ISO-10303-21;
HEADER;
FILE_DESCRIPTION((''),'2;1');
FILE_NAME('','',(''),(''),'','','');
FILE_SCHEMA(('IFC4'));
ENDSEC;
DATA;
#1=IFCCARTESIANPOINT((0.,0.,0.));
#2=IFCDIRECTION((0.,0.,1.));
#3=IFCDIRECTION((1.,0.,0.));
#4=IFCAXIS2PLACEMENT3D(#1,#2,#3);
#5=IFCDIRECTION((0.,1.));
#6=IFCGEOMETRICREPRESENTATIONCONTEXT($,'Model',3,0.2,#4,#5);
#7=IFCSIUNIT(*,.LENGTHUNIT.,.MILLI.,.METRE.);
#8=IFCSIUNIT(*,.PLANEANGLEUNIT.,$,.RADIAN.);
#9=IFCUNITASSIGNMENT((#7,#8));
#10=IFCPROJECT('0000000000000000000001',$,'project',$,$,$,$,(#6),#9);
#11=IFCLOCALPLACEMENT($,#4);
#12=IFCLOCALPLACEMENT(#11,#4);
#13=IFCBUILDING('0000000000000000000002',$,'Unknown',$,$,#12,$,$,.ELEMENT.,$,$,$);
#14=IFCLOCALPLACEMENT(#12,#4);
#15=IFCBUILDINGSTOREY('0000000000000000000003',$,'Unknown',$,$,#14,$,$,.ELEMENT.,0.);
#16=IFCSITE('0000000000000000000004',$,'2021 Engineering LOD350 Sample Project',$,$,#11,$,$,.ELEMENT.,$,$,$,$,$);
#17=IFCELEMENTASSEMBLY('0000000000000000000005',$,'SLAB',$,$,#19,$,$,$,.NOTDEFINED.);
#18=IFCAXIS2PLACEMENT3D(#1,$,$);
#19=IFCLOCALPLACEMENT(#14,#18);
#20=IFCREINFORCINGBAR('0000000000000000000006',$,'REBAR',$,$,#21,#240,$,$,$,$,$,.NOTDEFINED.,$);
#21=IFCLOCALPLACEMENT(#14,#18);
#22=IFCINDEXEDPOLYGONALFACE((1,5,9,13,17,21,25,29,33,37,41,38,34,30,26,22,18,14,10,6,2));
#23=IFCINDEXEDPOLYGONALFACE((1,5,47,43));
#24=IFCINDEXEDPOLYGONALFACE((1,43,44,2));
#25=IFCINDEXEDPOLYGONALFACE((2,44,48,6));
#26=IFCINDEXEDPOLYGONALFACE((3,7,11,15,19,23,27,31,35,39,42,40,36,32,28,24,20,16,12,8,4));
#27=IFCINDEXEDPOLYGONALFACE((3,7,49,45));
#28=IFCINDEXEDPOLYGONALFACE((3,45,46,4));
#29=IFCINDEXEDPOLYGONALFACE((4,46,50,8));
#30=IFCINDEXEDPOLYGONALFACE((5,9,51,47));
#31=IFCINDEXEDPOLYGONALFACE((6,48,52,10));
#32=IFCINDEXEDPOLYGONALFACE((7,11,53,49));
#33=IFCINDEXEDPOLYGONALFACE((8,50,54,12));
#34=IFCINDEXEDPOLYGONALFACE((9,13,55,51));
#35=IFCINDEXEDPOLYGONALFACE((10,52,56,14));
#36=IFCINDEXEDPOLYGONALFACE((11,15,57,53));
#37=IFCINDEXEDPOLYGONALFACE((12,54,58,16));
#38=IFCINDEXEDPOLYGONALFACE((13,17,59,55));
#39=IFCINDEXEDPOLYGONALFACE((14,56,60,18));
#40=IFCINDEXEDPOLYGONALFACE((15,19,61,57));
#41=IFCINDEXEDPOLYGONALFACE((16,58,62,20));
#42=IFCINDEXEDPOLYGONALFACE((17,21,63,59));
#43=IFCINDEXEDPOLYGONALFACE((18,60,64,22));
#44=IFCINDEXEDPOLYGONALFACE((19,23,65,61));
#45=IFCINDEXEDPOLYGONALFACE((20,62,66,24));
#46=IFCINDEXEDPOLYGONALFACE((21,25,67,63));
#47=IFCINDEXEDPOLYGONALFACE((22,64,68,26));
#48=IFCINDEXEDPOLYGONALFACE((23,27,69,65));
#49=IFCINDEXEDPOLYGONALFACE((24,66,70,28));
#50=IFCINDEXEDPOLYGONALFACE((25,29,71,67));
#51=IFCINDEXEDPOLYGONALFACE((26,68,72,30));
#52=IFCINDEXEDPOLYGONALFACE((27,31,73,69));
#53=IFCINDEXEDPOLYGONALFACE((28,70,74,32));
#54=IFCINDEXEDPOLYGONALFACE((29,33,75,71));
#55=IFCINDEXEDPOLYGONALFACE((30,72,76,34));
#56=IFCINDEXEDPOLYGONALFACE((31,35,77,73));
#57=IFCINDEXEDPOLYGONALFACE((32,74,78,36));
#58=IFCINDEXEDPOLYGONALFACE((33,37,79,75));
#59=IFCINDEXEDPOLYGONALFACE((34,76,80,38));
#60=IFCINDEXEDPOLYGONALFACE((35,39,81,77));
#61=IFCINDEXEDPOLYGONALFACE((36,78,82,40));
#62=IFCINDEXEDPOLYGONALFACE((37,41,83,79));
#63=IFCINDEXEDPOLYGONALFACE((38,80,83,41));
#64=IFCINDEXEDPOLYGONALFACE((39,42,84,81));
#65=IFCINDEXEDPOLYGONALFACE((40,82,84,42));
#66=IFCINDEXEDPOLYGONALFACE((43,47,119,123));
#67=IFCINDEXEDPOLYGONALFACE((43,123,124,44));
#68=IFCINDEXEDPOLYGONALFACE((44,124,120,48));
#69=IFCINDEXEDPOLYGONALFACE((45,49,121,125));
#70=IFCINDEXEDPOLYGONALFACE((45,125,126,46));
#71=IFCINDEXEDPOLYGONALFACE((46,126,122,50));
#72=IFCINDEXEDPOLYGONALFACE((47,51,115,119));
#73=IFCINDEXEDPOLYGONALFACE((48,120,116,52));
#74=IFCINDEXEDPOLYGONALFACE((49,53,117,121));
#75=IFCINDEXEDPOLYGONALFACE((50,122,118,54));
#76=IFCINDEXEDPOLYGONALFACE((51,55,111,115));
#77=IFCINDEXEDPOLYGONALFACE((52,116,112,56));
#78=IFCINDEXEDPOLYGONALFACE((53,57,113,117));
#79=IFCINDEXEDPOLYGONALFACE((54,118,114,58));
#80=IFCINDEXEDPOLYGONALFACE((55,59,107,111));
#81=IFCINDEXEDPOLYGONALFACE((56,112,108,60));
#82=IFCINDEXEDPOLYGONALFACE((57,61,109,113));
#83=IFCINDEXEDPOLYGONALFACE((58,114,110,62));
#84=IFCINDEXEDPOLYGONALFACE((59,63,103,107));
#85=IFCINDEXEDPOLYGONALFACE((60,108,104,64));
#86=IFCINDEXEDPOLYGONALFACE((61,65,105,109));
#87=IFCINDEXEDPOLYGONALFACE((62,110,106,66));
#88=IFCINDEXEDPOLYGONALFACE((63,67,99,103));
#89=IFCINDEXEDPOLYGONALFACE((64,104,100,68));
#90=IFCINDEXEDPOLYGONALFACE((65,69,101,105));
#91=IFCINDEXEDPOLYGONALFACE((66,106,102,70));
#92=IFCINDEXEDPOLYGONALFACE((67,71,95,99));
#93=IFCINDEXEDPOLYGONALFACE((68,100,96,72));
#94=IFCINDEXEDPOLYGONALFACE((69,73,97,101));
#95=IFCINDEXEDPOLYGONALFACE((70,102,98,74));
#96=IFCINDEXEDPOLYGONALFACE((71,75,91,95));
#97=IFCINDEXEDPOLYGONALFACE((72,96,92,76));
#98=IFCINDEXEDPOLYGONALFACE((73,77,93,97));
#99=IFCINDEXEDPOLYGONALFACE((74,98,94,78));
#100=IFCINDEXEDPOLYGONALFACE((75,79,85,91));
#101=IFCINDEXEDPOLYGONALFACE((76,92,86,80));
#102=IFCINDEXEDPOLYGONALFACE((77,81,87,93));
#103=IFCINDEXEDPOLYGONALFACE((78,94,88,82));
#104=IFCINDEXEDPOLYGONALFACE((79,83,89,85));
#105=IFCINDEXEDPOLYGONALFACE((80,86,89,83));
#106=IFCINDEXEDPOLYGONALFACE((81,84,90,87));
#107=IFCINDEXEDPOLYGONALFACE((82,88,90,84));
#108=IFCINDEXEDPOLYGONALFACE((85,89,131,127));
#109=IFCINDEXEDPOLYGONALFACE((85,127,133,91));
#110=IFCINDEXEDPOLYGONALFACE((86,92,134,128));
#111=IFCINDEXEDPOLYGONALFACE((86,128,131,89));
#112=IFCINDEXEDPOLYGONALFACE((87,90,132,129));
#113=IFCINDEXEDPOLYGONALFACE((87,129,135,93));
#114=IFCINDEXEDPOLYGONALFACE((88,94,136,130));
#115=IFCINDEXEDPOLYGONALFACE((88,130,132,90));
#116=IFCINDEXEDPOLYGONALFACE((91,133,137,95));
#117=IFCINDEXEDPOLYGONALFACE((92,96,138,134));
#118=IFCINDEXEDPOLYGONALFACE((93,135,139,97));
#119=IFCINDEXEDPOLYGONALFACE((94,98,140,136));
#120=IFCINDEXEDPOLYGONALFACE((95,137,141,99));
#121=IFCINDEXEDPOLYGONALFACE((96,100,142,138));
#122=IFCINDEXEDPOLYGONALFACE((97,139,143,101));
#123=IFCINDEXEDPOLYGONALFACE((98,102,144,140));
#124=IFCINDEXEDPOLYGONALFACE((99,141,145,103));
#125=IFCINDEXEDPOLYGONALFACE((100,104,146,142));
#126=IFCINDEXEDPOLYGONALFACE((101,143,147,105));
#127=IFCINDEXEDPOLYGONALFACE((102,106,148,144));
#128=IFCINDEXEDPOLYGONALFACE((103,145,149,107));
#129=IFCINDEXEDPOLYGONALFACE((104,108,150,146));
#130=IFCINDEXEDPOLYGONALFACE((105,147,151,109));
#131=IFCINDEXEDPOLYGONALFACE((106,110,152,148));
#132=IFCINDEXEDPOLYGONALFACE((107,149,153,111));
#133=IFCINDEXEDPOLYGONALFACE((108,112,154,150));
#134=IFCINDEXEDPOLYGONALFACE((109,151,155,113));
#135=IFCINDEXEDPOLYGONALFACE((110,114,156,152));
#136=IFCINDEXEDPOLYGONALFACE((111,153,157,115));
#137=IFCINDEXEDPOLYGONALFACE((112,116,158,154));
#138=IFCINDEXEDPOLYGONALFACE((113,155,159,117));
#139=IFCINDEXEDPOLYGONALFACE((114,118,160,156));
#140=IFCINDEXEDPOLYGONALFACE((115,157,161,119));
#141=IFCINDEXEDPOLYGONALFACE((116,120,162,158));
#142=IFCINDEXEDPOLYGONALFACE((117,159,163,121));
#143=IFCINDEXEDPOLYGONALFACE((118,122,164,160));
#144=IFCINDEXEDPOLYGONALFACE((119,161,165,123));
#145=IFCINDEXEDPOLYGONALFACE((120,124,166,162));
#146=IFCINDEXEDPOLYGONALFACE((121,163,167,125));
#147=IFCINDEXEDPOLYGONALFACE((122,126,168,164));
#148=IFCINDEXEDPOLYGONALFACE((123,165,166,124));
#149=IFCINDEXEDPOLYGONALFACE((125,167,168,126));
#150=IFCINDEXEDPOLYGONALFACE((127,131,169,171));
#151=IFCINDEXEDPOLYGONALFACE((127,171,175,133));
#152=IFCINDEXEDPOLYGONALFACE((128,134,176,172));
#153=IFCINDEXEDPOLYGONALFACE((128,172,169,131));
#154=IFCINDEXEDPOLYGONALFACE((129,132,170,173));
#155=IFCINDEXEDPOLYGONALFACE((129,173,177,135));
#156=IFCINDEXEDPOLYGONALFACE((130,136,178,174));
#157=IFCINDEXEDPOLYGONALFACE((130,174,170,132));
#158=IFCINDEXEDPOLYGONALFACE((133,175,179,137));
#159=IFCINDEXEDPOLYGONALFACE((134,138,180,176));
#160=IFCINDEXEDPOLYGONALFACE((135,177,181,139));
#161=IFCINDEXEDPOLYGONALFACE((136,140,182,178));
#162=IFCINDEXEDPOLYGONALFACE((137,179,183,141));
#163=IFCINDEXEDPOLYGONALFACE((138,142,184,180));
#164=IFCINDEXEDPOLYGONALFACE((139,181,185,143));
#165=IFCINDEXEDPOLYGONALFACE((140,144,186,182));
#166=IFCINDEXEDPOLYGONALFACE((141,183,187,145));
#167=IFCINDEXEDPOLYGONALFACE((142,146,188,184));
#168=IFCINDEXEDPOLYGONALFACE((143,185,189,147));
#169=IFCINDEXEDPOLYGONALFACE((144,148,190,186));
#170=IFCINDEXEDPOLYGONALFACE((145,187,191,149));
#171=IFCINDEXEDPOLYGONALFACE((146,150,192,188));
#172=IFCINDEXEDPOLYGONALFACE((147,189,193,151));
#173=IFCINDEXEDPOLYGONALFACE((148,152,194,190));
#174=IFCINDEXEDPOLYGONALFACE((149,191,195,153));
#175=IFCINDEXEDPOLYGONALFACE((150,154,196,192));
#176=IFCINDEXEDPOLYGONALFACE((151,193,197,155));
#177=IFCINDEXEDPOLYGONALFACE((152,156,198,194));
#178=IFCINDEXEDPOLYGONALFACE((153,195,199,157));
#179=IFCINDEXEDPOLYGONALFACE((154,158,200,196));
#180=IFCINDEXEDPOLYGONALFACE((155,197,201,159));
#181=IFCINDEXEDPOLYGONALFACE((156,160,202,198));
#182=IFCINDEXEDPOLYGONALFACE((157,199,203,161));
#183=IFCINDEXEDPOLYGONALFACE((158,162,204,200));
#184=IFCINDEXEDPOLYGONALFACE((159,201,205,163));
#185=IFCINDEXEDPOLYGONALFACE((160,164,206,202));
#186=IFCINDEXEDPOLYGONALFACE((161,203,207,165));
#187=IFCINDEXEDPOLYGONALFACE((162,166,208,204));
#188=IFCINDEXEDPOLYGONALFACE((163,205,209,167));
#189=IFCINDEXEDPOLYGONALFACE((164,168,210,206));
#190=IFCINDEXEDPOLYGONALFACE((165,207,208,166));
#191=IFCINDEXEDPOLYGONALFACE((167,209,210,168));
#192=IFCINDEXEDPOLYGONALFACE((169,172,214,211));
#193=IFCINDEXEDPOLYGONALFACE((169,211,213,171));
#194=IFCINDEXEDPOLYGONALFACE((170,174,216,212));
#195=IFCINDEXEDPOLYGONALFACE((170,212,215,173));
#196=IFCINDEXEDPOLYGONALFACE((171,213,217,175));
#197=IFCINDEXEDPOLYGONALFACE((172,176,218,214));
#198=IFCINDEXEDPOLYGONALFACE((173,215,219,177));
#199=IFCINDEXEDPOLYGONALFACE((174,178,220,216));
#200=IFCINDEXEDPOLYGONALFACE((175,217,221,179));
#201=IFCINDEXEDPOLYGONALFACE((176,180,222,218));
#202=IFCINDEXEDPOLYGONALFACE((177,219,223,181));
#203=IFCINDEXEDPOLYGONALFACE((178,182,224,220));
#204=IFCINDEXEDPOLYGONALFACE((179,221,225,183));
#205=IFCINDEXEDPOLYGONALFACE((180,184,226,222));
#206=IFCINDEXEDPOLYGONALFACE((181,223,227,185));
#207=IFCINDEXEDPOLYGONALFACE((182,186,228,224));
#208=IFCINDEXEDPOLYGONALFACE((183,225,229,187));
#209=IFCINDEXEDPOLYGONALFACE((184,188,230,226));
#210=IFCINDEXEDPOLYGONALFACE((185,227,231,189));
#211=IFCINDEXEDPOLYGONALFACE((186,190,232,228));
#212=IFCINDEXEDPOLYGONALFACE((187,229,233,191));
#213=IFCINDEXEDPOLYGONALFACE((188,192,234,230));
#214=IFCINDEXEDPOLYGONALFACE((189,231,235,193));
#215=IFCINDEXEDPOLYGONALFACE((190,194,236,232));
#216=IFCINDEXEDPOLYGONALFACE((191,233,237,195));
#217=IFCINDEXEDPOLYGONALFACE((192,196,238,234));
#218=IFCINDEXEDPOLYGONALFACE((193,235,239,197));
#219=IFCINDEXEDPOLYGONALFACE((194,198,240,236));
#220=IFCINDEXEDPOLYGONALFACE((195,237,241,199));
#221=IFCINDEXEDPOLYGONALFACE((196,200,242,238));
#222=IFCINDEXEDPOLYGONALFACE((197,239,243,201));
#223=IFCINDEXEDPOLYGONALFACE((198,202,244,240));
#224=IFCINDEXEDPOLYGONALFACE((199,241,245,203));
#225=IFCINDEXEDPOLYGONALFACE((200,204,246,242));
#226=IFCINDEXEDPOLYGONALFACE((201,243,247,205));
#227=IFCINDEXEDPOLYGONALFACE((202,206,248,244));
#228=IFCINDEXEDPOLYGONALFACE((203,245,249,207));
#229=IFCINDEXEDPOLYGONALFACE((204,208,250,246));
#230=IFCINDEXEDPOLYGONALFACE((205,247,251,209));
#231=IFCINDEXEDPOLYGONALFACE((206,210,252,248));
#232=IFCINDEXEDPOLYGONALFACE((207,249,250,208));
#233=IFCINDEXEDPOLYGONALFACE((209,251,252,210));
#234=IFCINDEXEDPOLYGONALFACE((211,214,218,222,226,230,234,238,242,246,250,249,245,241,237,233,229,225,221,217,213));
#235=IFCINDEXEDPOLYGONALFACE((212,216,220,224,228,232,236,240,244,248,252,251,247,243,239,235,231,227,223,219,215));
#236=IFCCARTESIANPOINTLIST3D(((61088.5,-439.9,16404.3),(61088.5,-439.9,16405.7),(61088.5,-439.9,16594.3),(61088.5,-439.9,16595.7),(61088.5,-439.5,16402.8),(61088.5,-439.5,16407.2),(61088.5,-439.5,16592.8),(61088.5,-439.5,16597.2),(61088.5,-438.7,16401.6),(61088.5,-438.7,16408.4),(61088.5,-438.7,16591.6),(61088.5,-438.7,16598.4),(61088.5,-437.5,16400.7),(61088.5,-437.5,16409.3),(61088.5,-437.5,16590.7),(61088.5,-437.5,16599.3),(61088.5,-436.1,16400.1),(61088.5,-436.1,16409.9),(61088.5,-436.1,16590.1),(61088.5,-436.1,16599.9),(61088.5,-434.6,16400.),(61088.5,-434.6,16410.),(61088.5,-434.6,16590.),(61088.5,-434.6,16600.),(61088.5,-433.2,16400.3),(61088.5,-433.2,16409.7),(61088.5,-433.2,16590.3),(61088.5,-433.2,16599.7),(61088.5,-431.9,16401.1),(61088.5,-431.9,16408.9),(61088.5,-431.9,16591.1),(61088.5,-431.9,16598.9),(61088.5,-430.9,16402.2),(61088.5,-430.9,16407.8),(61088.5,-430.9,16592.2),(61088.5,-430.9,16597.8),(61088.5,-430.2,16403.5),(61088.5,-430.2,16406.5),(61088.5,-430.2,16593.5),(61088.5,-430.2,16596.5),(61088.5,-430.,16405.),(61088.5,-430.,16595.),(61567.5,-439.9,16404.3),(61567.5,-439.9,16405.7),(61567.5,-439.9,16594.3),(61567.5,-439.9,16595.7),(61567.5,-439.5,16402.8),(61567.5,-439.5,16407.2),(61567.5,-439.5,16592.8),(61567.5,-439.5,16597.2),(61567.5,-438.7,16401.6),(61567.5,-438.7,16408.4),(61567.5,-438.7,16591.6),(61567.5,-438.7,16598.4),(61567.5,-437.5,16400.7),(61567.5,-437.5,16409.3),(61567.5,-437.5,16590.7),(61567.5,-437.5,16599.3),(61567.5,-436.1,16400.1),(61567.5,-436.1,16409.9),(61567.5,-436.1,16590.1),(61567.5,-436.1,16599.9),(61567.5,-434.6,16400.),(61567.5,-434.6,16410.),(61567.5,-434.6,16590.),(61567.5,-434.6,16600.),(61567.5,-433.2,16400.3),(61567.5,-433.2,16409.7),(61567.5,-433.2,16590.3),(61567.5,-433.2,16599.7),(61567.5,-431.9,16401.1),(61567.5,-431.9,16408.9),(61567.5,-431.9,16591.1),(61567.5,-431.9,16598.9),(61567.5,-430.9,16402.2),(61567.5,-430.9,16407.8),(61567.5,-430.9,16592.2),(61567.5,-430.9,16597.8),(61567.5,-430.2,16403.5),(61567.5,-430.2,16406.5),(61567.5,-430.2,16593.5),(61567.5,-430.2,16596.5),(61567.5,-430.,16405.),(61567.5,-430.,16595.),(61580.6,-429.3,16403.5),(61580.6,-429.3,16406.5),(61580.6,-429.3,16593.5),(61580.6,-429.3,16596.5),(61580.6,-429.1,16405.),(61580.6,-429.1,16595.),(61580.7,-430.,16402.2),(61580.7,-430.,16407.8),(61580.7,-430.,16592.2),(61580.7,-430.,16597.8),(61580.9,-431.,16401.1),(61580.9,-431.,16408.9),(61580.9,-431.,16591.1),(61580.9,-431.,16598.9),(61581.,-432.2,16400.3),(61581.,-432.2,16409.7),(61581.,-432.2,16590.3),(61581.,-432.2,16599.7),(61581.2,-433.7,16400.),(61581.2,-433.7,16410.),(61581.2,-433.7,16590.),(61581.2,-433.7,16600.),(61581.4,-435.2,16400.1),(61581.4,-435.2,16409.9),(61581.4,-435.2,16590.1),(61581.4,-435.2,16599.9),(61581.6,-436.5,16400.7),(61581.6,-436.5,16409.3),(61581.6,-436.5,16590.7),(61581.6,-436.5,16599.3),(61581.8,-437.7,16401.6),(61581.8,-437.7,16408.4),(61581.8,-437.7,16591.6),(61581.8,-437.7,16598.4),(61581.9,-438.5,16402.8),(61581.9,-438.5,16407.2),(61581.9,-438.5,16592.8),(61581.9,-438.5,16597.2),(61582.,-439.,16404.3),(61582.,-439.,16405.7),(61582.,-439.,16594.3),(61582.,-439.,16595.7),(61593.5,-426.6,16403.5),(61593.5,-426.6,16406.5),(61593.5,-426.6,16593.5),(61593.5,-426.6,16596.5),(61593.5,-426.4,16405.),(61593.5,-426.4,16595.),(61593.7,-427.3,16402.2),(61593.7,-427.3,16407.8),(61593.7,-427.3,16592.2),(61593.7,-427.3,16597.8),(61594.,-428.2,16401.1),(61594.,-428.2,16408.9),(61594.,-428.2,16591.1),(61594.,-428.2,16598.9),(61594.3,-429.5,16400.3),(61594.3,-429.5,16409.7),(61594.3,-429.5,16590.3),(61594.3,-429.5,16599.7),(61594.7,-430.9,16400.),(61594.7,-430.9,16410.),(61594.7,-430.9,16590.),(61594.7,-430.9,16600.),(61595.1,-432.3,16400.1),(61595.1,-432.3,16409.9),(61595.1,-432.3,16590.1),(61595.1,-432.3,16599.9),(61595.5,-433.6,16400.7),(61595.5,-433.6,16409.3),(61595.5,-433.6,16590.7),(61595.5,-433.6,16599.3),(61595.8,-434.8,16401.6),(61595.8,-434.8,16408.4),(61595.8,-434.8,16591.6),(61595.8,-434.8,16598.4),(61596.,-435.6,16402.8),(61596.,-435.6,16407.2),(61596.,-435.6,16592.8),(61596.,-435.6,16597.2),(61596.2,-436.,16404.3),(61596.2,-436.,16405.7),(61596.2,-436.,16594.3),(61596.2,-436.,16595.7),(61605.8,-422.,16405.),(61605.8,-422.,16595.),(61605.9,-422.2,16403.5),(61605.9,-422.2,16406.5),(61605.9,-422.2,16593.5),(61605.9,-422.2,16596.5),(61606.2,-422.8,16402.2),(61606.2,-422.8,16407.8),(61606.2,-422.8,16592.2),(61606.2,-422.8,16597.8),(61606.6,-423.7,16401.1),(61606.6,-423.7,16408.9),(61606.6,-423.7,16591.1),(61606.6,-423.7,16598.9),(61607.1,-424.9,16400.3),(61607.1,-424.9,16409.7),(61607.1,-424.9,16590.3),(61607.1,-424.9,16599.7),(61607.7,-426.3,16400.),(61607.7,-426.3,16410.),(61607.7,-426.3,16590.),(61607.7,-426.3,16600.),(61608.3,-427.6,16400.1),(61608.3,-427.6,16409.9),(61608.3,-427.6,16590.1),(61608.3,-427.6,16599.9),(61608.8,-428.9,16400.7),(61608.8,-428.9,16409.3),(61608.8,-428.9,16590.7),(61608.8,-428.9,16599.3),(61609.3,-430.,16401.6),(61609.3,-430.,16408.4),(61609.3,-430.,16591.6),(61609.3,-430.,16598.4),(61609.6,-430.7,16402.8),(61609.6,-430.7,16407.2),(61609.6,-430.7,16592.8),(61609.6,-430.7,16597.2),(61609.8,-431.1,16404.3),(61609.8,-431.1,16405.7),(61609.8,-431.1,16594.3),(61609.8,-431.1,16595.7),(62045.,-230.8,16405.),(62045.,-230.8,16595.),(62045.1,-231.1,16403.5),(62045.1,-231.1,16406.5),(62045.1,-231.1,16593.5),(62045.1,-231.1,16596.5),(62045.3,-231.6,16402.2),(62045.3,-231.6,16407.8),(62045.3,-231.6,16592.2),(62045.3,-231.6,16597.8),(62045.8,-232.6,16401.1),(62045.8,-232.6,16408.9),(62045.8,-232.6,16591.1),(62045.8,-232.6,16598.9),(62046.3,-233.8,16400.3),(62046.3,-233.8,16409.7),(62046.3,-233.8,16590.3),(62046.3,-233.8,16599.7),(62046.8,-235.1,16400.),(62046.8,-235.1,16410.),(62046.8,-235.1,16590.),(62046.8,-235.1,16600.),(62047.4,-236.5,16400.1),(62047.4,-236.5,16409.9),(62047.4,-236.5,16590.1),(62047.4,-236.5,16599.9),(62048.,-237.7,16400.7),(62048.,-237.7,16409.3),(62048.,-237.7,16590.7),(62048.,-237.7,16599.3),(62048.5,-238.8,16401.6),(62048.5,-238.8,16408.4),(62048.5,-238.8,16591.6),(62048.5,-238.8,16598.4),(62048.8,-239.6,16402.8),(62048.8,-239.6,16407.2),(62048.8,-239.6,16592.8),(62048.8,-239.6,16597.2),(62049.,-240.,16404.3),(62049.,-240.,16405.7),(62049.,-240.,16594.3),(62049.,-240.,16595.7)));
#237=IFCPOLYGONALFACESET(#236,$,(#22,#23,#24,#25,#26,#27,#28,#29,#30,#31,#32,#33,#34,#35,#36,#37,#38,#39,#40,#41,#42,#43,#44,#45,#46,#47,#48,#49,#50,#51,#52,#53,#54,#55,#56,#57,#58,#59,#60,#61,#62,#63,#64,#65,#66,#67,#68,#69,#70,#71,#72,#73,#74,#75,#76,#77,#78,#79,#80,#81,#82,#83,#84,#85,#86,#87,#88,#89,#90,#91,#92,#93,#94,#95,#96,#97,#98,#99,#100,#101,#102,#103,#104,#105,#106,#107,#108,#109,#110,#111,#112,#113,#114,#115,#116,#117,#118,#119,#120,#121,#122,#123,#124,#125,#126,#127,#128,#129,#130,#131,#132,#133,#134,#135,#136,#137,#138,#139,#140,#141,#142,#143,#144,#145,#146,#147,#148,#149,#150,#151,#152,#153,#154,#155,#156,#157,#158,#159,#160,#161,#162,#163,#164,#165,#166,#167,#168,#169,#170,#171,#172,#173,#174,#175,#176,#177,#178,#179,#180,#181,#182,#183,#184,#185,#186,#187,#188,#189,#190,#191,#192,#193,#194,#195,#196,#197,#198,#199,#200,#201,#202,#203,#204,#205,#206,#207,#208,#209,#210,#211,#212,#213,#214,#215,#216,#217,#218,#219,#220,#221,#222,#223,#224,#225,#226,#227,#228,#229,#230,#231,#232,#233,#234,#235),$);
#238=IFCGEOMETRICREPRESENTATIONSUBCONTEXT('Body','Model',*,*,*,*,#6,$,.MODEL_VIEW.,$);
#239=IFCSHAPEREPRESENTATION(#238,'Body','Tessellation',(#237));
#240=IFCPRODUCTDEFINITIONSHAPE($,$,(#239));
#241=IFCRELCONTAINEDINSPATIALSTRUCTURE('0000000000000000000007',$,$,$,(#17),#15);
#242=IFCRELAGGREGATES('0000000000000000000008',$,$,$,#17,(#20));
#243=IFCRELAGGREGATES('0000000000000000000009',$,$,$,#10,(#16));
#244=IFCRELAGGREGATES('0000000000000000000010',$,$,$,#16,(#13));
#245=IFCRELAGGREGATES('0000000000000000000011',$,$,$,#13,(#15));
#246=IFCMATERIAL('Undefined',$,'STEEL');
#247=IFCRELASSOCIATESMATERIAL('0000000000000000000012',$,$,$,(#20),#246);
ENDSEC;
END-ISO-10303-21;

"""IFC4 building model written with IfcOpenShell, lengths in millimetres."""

from ifc_helpers import new_model, entity, si_unit, direction, frame, origin_with_axes, place, context, subcontext, project, spatial, source, transform, mapped, material, element, aggregate, save


model = new_model("IFC4")

# Units and contexts
model_context = context("Model", 3, precision=0.2, world=origin_with_axes(), true_north=direction((0.0, 1.0)))
body_context = subcontext(model_context, "Body", "Model", "MODEL_VIEW")
ifc_project = project(units=[si_unit("LENGTHUNIT", "METRE", prefix="MILLI"), si_unit("PLANEANGLEUNIT", "RADIAN")], contexts=[model_context])

# Site, building, storey
site_placement = place(None, origin_with_axes())
site = spatial("IfcSite", under=ifc_project, at=site_placement, Name="2021 Engineering LOD350 Sample Project", CompositionType="ELEMENT")
building_placement = place(site_placement, origin_with_axes())
building = spatial("IfcBuilding", under=site, at=building_placement, Name="Unknown", CompositionType="ELEMENT")
storey_placement = place(building_placement, origin_with_axes())
storey = spatial("IfcBuildingStorey", under=building, at=storey_placement, Name="Unknown", CompositionType="ELEMENT", Elevation=0.0)

# Element assembly, reinforcing bar
assembly_1_placement = place(storey_placement, frame((61600.0, -490.0, 16500.0), z_axis=(0.0, 0.0, 1.0), x_axis=(0.916894, 0.399131, 0.0)))
assembly_1 = element("IfcElementAssembly", 1, at=assembly_1_placement, inside=storey, Name="SLAB", PredefinedType="NOTDEFINED")
ifc_material_1 = material(Name="Undefined", Category="STEEL")
shared_shape_1 = source(origin_with_axes(), body_context, "Body", "AdvancedSweptSolid", [
    entity("IfcSweptDiskSolid", entity("IfcIndexedPolyCurve", entity("IfcCartesianPointList3D", [[-458.4, 199.6, 0.0], [-19.3, 8.4, 0.0], [0.4, 2.1, 0.0], [21.0, 0.0, 0.0], [500.0, 0.0, 0.0]]), [entity("IfcLineIndex", [1, 2]), entity("IfcArcIndex", [2, 3, 4]), entity("IfcLineIndex", [4, 5])]), 5.0),
])
reinforcing_bar_1_placement = place(assembly_1_placement, frame((11.5, 55.0, -95.0), z_axis=(0.0, 0.0, 1.0), x_axis=(1.0, 0.0, 0.0)))
reinforcing_bar_1 = element("IfcReinforcingBar", 2, at=reinforcing_bar_1_placement, material=ifc_material_1, Name="REBAR", PredefinedType="NOTDEFINED", context=body_context, shape_type="MappedRepresentation", body=[
    mapped(shared_shape_1, transform((0.0, 0.0, 0.0))),
    mapped(shared_shape_1, transform((0.0, 0.0, 190.0))),
])

aggregate(assembly_1, [reinforcing_bar_1])

save(model, "model.ifc")
